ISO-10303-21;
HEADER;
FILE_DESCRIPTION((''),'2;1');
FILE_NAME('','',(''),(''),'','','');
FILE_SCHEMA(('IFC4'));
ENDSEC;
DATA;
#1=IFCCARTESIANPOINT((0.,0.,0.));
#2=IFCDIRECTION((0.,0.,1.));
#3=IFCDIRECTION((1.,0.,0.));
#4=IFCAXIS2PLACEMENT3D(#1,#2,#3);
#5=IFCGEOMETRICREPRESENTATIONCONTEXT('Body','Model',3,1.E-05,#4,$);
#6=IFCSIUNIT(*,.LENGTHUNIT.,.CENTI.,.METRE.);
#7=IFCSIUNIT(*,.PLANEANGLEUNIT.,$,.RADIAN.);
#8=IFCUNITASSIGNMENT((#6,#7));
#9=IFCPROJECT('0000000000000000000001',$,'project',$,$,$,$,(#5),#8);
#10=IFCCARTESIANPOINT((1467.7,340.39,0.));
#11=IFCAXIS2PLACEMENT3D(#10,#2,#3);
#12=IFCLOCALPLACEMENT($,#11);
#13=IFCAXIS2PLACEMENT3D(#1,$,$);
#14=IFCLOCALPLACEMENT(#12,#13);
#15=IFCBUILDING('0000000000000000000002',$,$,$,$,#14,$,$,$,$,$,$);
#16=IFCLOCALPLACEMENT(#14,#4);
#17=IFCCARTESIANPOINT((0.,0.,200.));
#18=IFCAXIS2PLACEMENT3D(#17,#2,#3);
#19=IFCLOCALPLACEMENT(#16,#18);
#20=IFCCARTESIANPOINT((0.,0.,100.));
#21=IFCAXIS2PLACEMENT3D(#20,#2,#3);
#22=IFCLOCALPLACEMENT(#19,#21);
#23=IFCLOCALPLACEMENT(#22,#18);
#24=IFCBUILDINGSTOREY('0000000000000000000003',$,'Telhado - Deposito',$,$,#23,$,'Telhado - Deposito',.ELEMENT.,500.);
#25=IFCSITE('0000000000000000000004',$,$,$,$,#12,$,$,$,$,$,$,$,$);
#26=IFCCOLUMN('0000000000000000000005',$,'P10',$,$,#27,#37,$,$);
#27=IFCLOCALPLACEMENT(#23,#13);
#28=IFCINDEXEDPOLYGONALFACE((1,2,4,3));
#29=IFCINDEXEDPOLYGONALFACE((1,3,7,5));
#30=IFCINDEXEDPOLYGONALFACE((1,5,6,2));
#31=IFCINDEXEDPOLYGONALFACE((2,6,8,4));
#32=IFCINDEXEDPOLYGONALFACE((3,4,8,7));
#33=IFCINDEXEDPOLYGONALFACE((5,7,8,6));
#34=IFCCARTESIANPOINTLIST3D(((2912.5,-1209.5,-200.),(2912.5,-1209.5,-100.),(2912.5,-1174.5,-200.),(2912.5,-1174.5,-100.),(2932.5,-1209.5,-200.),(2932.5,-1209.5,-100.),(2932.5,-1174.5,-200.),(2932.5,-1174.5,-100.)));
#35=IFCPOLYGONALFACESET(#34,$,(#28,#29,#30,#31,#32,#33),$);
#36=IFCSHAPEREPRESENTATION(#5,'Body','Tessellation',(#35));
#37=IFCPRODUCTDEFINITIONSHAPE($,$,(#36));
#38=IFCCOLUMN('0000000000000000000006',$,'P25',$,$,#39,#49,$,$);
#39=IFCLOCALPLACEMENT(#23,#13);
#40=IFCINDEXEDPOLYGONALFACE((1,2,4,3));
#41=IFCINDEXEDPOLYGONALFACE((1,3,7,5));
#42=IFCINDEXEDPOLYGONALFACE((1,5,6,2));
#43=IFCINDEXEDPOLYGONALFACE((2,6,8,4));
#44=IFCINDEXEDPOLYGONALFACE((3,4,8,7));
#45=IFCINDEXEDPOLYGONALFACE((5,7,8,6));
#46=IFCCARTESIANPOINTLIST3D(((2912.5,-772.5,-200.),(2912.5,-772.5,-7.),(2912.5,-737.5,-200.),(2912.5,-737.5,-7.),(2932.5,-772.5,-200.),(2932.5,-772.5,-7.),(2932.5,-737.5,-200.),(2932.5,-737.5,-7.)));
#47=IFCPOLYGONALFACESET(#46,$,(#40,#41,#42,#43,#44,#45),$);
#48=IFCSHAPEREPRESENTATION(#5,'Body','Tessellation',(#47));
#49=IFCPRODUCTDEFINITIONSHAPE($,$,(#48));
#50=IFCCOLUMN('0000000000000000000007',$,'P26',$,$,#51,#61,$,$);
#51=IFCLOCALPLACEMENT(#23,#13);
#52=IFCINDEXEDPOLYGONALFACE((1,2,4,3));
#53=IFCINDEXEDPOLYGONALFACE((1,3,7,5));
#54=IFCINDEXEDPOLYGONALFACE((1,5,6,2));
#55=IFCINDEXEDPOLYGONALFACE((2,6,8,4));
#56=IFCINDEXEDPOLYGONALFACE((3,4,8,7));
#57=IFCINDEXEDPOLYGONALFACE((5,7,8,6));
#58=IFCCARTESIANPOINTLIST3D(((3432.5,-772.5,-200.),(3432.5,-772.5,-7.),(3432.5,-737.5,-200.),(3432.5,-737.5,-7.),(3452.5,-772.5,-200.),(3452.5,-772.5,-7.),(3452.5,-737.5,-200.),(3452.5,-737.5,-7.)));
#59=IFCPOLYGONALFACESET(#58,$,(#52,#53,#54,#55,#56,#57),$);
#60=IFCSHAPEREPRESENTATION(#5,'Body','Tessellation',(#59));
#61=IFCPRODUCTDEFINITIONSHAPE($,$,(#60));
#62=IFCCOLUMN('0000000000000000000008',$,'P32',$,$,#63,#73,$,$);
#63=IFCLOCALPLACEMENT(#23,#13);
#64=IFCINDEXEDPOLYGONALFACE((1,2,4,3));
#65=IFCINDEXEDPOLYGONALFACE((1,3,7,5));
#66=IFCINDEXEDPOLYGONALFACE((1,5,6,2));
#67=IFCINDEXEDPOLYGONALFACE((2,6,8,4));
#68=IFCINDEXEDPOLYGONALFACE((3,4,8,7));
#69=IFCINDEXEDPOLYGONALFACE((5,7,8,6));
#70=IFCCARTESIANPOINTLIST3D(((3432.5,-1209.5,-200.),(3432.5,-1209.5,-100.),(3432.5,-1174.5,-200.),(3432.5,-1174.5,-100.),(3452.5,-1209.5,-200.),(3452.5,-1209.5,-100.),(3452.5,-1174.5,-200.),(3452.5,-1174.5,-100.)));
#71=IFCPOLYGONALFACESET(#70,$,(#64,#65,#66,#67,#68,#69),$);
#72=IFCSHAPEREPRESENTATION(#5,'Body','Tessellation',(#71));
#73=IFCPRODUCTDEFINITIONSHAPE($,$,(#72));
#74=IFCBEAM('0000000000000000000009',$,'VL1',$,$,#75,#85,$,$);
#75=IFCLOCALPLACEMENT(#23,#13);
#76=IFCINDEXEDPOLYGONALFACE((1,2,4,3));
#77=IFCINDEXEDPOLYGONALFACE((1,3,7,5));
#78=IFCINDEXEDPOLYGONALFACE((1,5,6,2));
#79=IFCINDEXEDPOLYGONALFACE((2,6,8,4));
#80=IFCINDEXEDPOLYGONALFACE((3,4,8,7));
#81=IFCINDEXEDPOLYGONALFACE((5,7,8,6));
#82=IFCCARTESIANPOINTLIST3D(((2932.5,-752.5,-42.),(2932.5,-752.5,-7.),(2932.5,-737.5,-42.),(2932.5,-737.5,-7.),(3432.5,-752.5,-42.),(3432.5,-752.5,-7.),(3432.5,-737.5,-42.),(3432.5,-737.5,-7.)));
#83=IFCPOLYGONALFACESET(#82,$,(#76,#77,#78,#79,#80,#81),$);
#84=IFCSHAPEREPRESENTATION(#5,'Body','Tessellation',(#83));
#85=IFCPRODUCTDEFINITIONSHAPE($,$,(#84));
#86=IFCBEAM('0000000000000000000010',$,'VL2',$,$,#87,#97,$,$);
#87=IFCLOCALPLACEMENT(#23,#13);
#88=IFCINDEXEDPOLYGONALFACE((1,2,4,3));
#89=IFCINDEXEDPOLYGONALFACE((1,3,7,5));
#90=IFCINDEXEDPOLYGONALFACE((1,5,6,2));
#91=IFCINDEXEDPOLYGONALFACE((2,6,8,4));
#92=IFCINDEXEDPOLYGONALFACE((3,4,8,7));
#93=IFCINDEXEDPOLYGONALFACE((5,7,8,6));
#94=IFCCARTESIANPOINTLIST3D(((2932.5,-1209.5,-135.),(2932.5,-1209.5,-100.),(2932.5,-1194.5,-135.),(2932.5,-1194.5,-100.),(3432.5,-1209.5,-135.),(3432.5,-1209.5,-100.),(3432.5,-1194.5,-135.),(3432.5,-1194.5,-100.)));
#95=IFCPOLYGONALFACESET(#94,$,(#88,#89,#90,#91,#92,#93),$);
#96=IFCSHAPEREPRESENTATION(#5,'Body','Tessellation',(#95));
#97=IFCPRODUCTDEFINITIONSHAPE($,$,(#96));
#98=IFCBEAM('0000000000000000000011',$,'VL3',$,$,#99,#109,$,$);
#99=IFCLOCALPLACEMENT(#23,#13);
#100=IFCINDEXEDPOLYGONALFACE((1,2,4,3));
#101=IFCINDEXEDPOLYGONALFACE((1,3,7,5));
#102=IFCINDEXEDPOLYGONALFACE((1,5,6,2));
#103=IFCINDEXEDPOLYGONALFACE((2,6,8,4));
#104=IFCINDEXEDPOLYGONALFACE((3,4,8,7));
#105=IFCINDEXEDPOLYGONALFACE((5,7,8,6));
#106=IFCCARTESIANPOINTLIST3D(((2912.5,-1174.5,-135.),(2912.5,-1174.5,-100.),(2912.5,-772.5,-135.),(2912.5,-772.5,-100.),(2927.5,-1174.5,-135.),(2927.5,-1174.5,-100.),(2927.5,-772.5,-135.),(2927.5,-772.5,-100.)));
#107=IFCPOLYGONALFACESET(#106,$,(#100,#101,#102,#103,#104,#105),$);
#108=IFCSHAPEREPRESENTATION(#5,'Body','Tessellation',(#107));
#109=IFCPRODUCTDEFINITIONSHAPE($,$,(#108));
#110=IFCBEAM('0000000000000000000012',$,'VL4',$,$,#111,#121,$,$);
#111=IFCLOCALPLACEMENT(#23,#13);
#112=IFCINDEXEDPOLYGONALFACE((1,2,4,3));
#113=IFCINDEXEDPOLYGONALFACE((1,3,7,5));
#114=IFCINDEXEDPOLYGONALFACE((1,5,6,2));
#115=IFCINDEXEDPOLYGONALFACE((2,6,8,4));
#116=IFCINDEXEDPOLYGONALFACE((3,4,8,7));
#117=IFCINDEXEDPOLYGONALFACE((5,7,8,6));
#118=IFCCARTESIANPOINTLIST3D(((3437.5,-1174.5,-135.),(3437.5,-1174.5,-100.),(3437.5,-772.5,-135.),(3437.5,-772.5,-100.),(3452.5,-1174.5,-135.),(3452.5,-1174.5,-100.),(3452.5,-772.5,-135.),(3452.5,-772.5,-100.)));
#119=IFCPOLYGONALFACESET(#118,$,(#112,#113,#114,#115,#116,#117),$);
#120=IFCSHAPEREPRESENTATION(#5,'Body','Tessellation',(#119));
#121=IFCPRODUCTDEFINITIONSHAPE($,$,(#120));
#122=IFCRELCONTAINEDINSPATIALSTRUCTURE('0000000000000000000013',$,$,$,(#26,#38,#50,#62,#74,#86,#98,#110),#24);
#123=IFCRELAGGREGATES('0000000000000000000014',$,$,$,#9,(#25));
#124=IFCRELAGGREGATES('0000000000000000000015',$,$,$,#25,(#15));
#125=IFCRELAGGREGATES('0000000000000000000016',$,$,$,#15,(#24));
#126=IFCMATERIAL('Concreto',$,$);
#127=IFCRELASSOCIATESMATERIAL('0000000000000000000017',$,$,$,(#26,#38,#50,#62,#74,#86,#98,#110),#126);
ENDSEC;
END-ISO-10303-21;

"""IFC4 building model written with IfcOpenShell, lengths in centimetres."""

from ifc_helpers import new_model, si_unit, frame, origin, origin_with_axes, origin_2d_with_axis, place, context, project, spatial, rectangle, extrude, material, element, save


model = new_model("IFC4")

# Units and contexts
model_context = context("Model", 3, precision=1e-05, world=origin_with_axes(), identifier="Body")
ifc_project = project(units=[si_unit("LENGTHUNIT", "METRE", prefix="CENTI"), si_unit("PLANEANGLEUNIT", "RADIAN")], contexts=[model_context])

# Site, building, storey
site_placement = place(None, frame((1467.7, 340.39, 0.0), z_axis=(0.0, 0.0, 1.0), x_axis=(1.0, 0.0, 0.0)))
site = spatial("IfcSite", under=ifc_project, at=site_placement)
building_placement = place(site_placement, origin())
building = spatial("IfcBuilding", under=site, at=building_placement)
placement_1 = place(building_placement, origin_with_axes())
placement_2 = place(placement_1, frame((0.0, 0.0, 200.0), z_axis=(0.0, 0.0, 1.0), x_axis=(1.0, 0.0, 0.0)))
placement_3 = place(placement_2, frame((0.0, 0.0, 100.0), z_axis=(0.0, 0.0, 1.0), x_axis=(1.0, 0.0, 0.0)))
storey_placement = place(placement_3, frame((0.0, 0.0, 200.0), z_axis=(0.0, 0.0, 1.0), x_axis=(1.0, 0.0, 0.0)))
storey = spatial("IfcBuildingStorey", under=building, at=storey_placement, Name="Telhado - Deposito", LongName="Telhado - Deposito", CompositionType="ELEMENT", Elevation=500.0)

# Columns
ifc_material = material(Name="Concreto")
column_1_placement = place(storey_placement, frame((2922.5, -1192.0, -100.0), z_axis=(0.0, 0.0, 1.0), x_axis=(1.0, 0.0, 0.0)))
element("IfcColumn", 1, at=column_1_placement, inside=storey, material=ifc_material, Name="P10", context=model_context, shape_type="SolidModel", body=[
    extrude(rectangle(XDim=20.0, YDim=35.0, at=origin_2d_with_axis()), origin_with_axes(), (0.0, 0.0, -1.0), 100.0),
])
column_2_placement = place(storey_placement, frame((2922.5, -755.0, -7.0), z_axis=(0.0, 0.0, 1.0), x_axis=(1.0, 0.0, 0.0)))
element("IfcColumn", 2, at=column_2_placement, inside=storey, material=ifc_material, Name="P25", context=model_context, shape_type="SolidModel", body=[
    extrude(rectangle(XDim=20.0, YDim=35.0, at=origin_2d_with_axis()), frame((0.0, 0.0, 0.0), z_axis=(0.0, 0.0, 1.0), x_axis=(-1.0, 0.0, 0.0)), (0.0, 0.0, -1.0), 193.0),
])
column_3_placement = place(storey_placement, frame((3442.5, -755.0, -7.0), z_axis=(0.0, 0.0, 1.0), x_axis=(1.0, 0.0, 0.0)))
element("IfcColumn", 3, at=column_3_placement, inside=storey, material=ifc_material, Name="P26", context=model_context, shape_type="SolidModel", body=[
    extrude(rectangle(XDim=20.0, YDim=35.0, at=origin_2d_with_axis()), origin_with_axes(), (0.0, 0.0, -1.0), 193.0),
])
column_4_placement = place(storey_placement, frame((3442.5, -1192.0, -100.0), z_axis=(0.0, 0.0, 1.0), x_axis=(1.0, 0.0, 0.0)))
element("IfcColumn", 4, at=column_4_placement, inside=storey, material=ifc_material, Name="P32", context=model_context, shape_type="SolidModel", body=[
    extrude(rectangle(XDim=20.0, YDim=35.0, at=origin_2d_with_axis()), origin_with_axes(), (0.0, 0.0, -1.0), 100.0),
])

# Beams
for number, where, z_axis, x_axis, name in (
    (5, (3182.5, -745.0, -7.0), (0.0, 0.0, 1.0), (1.0, 0.0, 0.0), "VL1"),
    (6, (3182.5, -1202.0, -100.0), (0.0, 0.0, 1.0), (1.0, 0.0, 0.0), "VL2"),
):
    element("IfcBeam", number, at=place(storey_placement, frame(where, z_axis=z_axis, x_axis=x_axis)), inside=storey, material=ifc_material, Name=name, context=model_context, shape_type="SolidModel", body=[
        extrude(rectangle(XDim=15.0, YDim=35.0, at=origin_2d_with_axis()), frame((-250.0, 0.0, -17.5), z_axis=(1.0, 0.0, 0.0), x_axis=(0.0, 1.0, 0.0)), (0.0, 0.0, 1.0), 500.0),
    ])
for number, where, z_axis, x_axis, name in (
    (7, (2920.0, -973.5, -100.0), (0.0, 0.0, 1.0), (1.0, 0.0, 0.0), "VL3"),
    (8, (3445.0, -973.5, -100.0), (0.0, 0.0, 1.0), (1.0, 0.0, 0.0), "VL4"),
):
    element("IfcBeam", number, at=place(storey_placement, frame(where, z_axis=z_axis, x_axis=x_axis)), inside=storey, material=ifc_material, Name=name, context=model_context, shape_type="SolidModel", body=[
        extrude(rectangle(XDim=15.0, YDim=35.0, at=origin_2d_with_axis()), frame((0.0, -201.0, -17.5), z_axis=(0.0, 1.0, 0.0), x_axis=(1.0, 0.0, 0.0)), (0.0, 0.0, 1.0), 402.0),
    ])

save(model, "model.ifc")
